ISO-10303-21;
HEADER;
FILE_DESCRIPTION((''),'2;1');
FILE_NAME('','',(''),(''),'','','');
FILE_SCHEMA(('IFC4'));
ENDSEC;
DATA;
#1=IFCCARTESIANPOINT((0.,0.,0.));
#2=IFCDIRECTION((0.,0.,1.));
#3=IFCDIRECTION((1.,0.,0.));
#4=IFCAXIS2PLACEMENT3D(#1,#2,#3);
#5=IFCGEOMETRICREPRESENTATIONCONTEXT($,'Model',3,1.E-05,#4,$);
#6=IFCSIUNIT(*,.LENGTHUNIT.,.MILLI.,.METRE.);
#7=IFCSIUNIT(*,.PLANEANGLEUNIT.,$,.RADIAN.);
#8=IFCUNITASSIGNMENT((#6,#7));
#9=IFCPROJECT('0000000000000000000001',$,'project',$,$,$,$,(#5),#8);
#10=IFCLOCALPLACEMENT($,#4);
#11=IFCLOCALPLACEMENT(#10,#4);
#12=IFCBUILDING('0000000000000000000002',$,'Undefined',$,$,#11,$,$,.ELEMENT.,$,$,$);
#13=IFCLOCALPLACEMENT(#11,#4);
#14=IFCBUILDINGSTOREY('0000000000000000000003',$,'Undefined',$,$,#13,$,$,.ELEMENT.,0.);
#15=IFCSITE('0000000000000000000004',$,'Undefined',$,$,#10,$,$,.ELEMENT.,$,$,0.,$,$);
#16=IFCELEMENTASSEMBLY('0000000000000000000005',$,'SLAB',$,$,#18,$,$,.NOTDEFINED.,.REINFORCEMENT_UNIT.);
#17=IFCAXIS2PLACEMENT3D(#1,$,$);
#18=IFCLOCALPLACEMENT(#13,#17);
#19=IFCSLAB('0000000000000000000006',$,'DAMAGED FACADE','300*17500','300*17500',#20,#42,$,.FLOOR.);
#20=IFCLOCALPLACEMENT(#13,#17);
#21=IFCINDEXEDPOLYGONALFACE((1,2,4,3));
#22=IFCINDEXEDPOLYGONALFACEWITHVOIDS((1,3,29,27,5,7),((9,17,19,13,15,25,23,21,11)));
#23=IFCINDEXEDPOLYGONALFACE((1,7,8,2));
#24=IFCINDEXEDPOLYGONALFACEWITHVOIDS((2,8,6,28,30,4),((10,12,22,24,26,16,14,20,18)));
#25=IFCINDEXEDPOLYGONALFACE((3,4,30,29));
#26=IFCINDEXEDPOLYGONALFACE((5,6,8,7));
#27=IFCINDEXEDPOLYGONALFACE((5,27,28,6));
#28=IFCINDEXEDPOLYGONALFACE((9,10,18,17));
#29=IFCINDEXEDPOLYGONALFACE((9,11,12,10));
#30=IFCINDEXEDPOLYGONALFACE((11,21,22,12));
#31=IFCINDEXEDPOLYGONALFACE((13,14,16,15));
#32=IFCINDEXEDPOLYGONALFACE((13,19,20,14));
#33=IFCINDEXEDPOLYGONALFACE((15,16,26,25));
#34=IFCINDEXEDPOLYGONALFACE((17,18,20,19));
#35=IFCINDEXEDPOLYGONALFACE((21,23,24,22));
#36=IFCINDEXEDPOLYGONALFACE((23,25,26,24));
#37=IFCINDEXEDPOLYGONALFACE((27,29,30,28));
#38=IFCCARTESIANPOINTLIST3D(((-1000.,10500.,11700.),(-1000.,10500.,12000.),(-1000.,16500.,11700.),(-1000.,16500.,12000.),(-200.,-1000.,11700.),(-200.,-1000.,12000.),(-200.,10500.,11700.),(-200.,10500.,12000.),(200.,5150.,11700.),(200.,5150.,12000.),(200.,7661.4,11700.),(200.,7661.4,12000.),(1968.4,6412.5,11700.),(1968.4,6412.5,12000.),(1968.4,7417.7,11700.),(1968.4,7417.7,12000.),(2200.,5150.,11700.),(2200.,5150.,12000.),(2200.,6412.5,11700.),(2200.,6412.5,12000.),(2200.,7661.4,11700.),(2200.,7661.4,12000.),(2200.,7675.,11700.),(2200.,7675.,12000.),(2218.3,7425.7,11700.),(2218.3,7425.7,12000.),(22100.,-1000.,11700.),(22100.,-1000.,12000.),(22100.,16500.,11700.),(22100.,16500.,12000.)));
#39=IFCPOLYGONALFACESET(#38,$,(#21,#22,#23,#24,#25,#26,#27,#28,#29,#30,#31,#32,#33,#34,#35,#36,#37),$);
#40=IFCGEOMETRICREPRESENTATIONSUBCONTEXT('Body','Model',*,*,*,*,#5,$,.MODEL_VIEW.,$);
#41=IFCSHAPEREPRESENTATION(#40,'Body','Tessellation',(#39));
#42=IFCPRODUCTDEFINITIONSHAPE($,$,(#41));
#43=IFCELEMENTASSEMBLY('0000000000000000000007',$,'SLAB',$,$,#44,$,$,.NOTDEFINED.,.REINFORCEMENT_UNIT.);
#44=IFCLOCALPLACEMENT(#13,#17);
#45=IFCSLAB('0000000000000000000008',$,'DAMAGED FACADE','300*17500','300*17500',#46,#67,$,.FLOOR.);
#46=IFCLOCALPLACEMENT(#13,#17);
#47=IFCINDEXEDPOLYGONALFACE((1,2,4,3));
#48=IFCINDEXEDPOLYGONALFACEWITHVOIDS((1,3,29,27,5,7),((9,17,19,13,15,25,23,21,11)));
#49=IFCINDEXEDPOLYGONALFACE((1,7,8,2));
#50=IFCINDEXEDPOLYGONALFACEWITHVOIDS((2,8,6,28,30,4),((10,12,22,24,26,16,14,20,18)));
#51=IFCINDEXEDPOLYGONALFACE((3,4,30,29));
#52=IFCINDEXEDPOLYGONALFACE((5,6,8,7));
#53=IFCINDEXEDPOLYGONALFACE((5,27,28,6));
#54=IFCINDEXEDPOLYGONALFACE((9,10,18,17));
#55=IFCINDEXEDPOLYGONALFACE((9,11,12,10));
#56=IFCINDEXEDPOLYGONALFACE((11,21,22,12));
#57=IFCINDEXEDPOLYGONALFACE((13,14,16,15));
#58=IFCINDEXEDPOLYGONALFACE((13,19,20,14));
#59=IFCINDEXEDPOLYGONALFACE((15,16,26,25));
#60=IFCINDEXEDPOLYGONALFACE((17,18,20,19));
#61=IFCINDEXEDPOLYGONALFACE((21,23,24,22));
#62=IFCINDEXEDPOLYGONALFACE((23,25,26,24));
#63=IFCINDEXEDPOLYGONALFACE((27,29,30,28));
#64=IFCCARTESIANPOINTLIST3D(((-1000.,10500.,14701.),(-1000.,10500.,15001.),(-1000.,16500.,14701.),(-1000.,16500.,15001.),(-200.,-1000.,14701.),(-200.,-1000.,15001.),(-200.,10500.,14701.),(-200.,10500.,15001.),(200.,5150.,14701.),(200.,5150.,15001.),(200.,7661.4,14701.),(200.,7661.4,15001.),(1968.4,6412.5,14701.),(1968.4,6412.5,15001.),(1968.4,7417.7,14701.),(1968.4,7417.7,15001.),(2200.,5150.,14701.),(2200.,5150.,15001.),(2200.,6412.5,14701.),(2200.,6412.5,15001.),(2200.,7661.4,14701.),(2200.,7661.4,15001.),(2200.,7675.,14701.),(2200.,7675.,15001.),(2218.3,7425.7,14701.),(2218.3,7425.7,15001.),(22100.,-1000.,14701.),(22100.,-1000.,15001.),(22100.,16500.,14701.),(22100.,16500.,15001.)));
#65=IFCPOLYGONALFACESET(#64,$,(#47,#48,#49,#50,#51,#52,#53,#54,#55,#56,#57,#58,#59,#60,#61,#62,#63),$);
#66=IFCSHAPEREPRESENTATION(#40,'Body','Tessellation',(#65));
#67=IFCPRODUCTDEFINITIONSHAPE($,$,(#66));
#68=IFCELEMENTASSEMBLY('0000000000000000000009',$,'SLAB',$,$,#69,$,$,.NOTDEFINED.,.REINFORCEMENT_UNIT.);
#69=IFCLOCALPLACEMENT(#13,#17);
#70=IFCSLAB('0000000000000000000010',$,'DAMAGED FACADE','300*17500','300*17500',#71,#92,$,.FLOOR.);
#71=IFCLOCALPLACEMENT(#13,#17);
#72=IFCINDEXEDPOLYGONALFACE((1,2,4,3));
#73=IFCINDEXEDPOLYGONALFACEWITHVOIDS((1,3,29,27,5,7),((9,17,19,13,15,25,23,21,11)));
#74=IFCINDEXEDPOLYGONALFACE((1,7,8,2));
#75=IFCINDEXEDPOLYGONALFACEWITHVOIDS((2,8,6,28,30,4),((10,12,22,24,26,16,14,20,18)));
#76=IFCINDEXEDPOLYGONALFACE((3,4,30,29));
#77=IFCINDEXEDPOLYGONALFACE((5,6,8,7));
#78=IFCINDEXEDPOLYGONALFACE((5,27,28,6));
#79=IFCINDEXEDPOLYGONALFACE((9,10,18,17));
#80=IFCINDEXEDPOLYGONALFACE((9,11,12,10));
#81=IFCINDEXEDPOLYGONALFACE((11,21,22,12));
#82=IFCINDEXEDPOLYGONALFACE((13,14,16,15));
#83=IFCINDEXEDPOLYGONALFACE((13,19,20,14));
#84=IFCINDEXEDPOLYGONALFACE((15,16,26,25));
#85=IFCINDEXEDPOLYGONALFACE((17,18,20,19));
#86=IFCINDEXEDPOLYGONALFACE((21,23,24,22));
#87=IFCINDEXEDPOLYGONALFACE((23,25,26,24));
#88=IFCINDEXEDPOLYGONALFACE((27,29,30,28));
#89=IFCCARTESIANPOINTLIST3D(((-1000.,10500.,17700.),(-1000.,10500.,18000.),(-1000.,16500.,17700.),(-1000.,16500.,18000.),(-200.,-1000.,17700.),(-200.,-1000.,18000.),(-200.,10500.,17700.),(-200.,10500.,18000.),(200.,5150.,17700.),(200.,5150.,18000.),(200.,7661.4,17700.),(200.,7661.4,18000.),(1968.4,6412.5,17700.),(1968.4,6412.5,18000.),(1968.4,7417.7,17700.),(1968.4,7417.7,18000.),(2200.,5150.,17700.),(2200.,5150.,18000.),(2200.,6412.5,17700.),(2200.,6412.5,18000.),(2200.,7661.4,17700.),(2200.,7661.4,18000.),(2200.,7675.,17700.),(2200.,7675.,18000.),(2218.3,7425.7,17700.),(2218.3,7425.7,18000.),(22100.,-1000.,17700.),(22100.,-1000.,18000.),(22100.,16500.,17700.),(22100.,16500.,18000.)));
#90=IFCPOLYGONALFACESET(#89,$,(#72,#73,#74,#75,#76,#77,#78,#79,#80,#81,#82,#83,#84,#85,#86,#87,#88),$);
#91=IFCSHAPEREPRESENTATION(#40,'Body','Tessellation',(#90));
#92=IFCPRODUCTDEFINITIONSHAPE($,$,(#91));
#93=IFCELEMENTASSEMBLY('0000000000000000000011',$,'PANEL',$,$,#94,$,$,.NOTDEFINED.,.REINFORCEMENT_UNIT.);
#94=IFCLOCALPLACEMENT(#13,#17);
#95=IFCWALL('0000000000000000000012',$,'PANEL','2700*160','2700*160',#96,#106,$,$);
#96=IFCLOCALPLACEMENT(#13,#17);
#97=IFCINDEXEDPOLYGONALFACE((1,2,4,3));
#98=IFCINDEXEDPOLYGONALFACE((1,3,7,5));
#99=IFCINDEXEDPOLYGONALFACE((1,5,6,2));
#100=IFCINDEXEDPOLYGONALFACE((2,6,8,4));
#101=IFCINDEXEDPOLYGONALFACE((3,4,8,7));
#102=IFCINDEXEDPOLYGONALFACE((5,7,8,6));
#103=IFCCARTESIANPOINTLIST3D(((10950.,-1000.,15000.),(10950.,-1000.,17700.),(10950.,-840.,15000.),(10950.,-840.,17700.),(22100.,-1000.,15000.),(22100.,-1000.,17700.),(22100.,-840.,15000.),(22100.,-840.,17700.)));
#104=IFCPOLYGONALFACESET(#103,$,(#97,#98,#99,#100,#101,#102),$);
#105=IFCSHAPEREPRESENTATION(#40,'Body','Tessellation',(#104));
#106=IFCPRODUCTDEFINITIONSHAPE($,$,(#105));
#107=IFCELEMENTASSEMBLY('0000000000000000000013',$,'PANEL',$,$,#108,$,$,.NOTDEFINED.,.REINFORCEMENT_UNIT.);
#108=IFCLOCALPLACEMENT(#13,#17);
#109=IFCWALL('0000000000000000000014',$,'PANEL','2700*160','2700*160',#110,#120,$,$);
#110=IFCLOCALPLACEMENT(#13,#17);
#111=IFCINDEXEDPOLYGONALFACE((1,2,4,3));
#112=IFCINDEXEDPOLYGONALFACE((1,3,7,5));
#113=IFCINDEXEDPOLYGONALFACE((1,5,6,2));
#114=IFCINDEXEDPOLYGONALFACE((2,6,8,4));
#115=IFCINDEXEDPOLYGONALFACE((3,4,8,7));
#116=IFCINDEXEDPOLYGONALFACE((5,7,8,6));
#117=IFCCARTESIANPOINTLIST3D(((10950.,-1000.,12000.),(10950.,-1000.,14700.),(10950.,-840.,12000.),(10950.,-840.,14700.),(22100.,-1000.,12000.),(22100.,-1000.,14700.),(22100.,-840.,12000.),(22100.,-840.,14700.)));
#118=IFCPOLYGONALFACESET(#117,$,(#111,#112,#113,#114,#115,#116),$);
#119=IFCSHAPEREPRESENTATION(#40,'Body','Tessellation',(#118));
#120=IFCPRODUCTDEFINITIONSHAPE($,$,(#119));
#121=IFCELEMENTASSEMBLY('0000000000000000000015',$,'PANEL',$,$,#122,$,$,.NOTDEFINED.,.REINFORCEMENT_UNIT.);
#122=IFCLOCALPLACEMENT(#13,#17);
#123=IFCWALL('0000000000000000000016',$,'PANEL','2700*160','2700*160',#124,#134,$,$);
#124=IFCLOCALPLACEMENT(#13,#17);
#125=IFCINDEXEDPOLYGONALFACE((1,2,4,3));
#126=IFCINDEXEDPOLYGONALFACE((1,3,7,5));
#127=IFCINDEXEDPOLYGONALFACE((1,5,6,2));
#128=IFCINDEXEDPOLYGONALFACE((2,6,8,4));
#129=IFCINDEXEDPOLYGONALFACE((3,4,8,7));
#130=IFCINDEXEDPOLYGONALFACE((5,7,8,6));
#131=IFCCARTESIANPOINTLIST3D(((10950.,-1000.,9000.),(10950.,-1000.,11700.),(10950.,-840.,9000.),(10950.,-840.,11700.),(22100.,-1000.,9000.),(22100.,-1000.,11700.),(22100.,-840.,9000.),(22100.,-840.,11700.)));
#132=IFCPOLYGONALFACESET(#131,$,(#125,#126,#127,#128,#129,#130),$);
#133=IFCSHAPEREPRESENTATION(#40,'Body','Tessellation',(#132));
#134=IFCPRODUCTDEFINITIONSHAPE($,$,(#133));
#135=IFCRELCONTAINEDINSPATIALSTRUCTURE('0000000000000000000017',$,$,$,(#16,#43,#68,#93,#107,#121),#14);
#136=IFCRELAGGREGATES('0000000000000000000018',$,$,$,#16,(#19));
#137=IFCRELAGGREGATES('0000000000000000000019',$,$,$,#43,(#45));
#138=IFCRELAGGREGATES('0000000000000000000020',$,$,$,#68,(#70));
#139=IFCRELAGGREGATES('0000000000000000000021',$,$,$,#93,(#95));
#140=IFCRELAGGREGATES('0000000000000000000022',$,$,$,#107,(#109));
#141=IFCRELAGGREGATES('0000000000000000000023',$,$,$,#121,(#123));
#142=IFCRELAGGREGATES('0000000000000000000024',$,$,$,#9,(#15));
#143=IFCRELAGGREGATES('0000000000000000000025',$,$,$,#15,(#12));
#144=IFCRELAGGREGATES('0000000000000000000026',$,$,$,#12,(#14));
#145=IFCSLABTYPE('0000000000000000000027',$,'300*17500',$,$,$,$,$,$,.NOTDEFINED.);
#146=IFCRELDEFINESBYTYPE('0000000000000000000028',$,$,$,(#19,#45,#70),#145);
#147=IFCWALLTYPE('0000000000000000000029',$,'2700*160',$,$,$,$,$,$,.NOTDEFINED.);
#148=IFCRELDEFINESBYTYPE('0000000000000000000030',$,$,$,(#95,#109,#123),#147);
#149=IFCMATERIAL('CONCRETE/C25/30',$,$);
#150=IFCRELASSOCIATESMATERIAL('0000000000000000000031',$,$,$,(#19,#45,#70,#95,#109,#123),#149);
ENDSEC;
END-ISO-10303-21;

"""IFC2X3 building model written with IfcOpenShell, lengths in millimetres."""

from ifc_helpers import new_model, si_unit, frame, frame_2d, origin_with_axes, place, context, subcontext, project, spatial, polyline, rectangle, outline, extrude, boolean, material, type_object, element, aggregate, save


model = new_model("IFC2X3")

# Units and contexts
model_context = context("Model", 3, precision=1e-05, world=origin_with_axes())
body_context = subcontext(model_context, "Body", "Model", "MODEL_VIEW")
ifc_project = project(units=[si_unit("LENGTHUNIT", "METRE", prefix="MILLI"), si_unit("PLANEANGLEUNIT", "RADIAN")], contexts=[model_context])

# Site, building, storey
site_placement = place(None, origin_with_axes())
site = spatial("IfcSite", under=ifc_project, at=site_placement, Name="Undefined", CompositionType="ELEMENT", RefElevation=0.0)
building_placement = place(site_placement, origin_with_axes())
building = spatial("IfcBuilding", under=site, at=building_placement, Name="Undefined", CompositionType="ELEMENT")
storey_placement = place(building_placement, origin_with_axes())
storey = spatial("IfcBuildingStorey", under=building, at=storey_placement, Name="Undefined", CompositionType="ELEMENT", Elevation=0.0)

# Shared definitions
ifc_material = material(Name="CONCRETE/C25/30")

# Element assemblies, slabs
assembly_1_placement = place(storey_placement, origin_with_axes())
assembly_1 = element("IfcElementAssembly", 1, at=assembly_1_placement, inside=storey, Name="SLAB", AssemblyPlace="NOTDEFINED", PredefinedType="REINFORCEMENT_UNIT")
slab_type = type_object("IfcSlabType", Name="300*17500", PredefinedType="NOTDEFINED")
slab_1_placement = place(assembly_1_placement, frame((22100.0, -1000.0, 11850.0), z_axis=(0.0, 0.0, 1.0), x_axis=(0.0, 1.0, 0.0)))
slab_1 = element("IfcSlab", 2, at=slab_1_placement, type_object=slab_type, material=ifc_material, Name="DAMAGED FACADE", Description="300*17500", ObjectType="300*17500", PredefinedType="FLOOR", context=body_context, shape_type="CSG", body=[
    boolean("DIFFERENCE", extrude(outline(polyline([(0.0, 0.0), (17500.0, 0.0), (17500.0, 23100.0), (11500.0, 23100.0), (11500.0, 22300.0), (0.0, 22300.0), (0.0, 0.0), (0.0, 0.0)])), frame((0.0, 0.0, -150.0), z_axis=(0.0, 0.0, 1.0), x_axis=(1.0, 0.0, 0.0)), (0.0, 0.0, 1.0), 300.0), extrude(outline(polyline([(0.0, 0.0), (2000.0, 0.0), (2000.0, -13.6), (2018.3, 235.8), (1768.4, 243.7), (1768.4, 1248.9), (2000.0, 1248.9), (2000.0, 2511.4), (0.0, 2511.4), (0.0, 0.0), (0.0, 0.0)])), frame((8661.4, 21900.0, 152.5), z_axis=(0.0, 0.0, -1.0), x_axis=(0.0, -1.0, 0.0)), (0.0, 0.0, 1.0), 305.0)),
])
aggregate(assembly_1, [slab_1])
assembly_2_placement = place(storey_placement, origin_with_axes())
assembly_2 = element("IfcElementAssembly", 3, at=assembly_2_placement, inside=storey, Name="SLAB", AssemblyPlace="NOTDEFINED", PredefinedType="REINFORCEMENT_UNIT")
slab_2_placement = place(assembly_2_placement, frame((22100.0, -1000.0, 14851.0), z_axis=(0.0, 0.0, 1.0), x_axis=(0.0, 1.0, 0.0)))
slab_2 = element("IfcSlab", 4, at=slab_2_placement, type_object=slab_type, material=ifc_material, Name="DAMAGED FACADE", Description="300*17500", ObjectType="300*17500", PredefinedType="FLOOR", context=body_context, shape_type="CSG", body=[
    boolean("DIFFERENCE", extrude(outline(polyline([(0.0, 0.0), (17500.0, 0.0), (17500.0, 23100.0), (11500.0, 23100.0), (11500.0, 22300.0), (0.0, 22300.0), (0.0, 0.0), (0.0, 0.0)])), frame((0.0, 0.0, -150.0), z_axis=(0.0, 0.0, 1.0), x_axis=(1.0, 0.0, 0.0)), (0.0, 0.0, 1.0), 300.0), extrude(outline(polyline([(0.0, 0.0), (2000.0, 0.0), (2000.0, -13.6), (2018.3, 235.8), (1768.4, 243.7), (1768.4, 1248.9), (2000.0, 1248.9), (2000.0, 2511.4), (0.0, 2511.4), (0.0, 0.0), (0.0, 0.0)])), frame((8661.4, 21900.0, 151.5), z_axis=(0.0, 0.0, -1.0), x_axis=(0.0, -1.0, 0.0)), (0.0, 0.0, 1.0), 305.0)),
])
aggregate(assembly_2, [slab_2])
assembly_3_placement = place(storey_placement, origin_with_axes())
assembly_3 = element("IfcElementAssembly", 5, at=assembly_3_placement, inside=storey, Name="SLAB", AssemblyPlace="NOTDEFINED", PredefinedType="REINFORCEMENT_UNIT")
slab_3_placement = place(assembly_3_placement, frame((22100.0, -1000.0, 17850.0), z_axis=(0.0, 0.0, 1.0), x_axis=(0.0, 1.0, 0.0)))
slab_3 = element("IfcSlab", 6, at=slab_3_placement, type_object=slab_type, material=ifc_material, Name="DAMAGED FACADE", Description="300*17500", ObjectType="300*17500", PredefinedType="FLOOR", context=body_context, shape_type="CSG", body=[
    boolean("DIFFERENCE", extrude(outline(polyline([(0.0, 0.0), (17500.0, 0.0), (17500.0, 23100.0), (11500.0, 23100.0), (11500.0, 22300.0), (0.0, 22300.0), (0.0, 0.0), (0.0, 0.0)])), frame((0.0, 0.0, -150.0), z_axis=(0.0, 0.0, 1.0), x_axis=(1.0, 0.0, 0.0)), (0.0, 0.0, 1.0), 300.0), extrude(outline(polyline([(0.0, 0.0), (2000.0, 0.0), (2000.0, -13.6), (2018.3, 235.8), (1768.4, 243.7), (1768.4, 1248.9), (2000.0, 1248.9), (2000.0, 2511.4), (0.0, 2511.4), (0.0, 0.0), (0.0, 0.0)])), frame((8661.4, 21900.0, 151.5), z_axis=(0.0, 0.0, -1.0), x_axis=(0.0, -1.0, 0.0)), (0.0, 0.0, 1.0), 305.0)),
])
aggregate(assembly_3, [slab_3])

# Element assemblies, walls
assembly_4_placement = place(storey_placement, origin_with_axes())
assembly_4 = element("IfcElementAssembly", 7, at=assembly_4_placement, inside=storey, Name="PANEL", AssemblyPlace="NOTDEFINED", PredefinedType="REINFORCEMENT_UNIT")
wall_type = type_object("IfcWallType", Name="2700*160", PredefinedType="NOTDEFINED")
wall_1_placement = place(assembly_4_placement, frame((10950.0, -920.0, 15000.0), z_axis=(0.0, 0.0, 1.0), x_axis=(1.0, 0.0, 0.0)))
wall_1 = element("IfcWall", 8, at=wall_1_placement, type_object=wall_type, material=ifc_material, Name="PANEL", Description="2700*160", ObjectType="2700*160", context=body_context, shape_type="SweptSolid", body=[
    extrude(rectangle(XDim=11150.0, YDim=160.0, at=frame_2d((0.0, 5575.0), x_axis=(0.0, -1.0))), frame((0.0, 0.0, 0.0), z_axis=(0.0, 0.0, 1.0), x_axis=(0.0, -1.0, 0.0)), (0.0, 0.0, 1.0), 2700.0),
])
aggregate(assembly_4, [wall_1])
assembly_5_placement = place(storey_placement, origin_with_axes())
assembly_5 = element("IfcElementAssembly", 9, at=assembly_5_placement, inside=storey, Name="PANEL", AssemblyPlace="NOTDEFINED", PredefinedType="REINFORCEMENT_UNIT")
wall_2_placement = place(assembly_5_placement, frame((10950.0, -920.0, 12000.0), z_axis=(0.0, 0.0, 1.0), x_axis=(1.0, 0.0, 0.0)))
wall_2 = element("IfcWall", 10, at=wall_2_placement, type_object=wall_type, material=ifc_material, Name="PANEL", Description="2700*160", ObjectType="2700*160", context=body_context, shape_type="SweptSolid", body=[
    extrude(rectangle(XDim=11150.0, YDim=160.0, at=frame_2d((0.0, 5575.0), x_axis=(0.0, -1.0))), frame((0.0, 0.0, 0.0), z_axis=(0.0, 0.0, 1.0), x_axis=(0.0, -1.0, 0.0)), (0.0, 0.0, 1.0), 2700.0),
])
aggregate(assembly_5, [wall_2])
assembly_6_placement = place(storey_placement, origin_with_axes())
assembly_6 = element("IfcElementAssembly", 11, at=assembly_6_placement, inside=storey, Name="PANEL", AssemblyPlace="NOTDEFINED", PredefinedType="REINFORCEMENT_UNIT")
wall_3_placement = place(assembly_6_placement, frame((10950.0, -920.0, 9000.0), z_axis=(0.0, 0.0, 1.0), x_axis=(1.0, 0.0, 0.0)))
wall_3 = element("IfcWall", 12, at=wall_3_placement, type_object=wall_type, material=ifc_material, Name="PANEL", Description="2700*160", ObjectType="2700*160", context=body_context, shape_type="SweptSolid", body=[
    extrude(rectangle(XDim=11150.0, YDim=160.0, at=frame_2d((0.0, 5575.0), x_axis=(0.0, -1.0))), frame((0.0, 0.0, 0.0), z_axis=(0.0, 0.0, 1.0), x_axis=(0.0, -1.0, 0.0)), (0.0, 0.0, 1.0), 2700.0),
])
aggregate(assembly_6, [wall_3])

save(model, "model.ifc")
